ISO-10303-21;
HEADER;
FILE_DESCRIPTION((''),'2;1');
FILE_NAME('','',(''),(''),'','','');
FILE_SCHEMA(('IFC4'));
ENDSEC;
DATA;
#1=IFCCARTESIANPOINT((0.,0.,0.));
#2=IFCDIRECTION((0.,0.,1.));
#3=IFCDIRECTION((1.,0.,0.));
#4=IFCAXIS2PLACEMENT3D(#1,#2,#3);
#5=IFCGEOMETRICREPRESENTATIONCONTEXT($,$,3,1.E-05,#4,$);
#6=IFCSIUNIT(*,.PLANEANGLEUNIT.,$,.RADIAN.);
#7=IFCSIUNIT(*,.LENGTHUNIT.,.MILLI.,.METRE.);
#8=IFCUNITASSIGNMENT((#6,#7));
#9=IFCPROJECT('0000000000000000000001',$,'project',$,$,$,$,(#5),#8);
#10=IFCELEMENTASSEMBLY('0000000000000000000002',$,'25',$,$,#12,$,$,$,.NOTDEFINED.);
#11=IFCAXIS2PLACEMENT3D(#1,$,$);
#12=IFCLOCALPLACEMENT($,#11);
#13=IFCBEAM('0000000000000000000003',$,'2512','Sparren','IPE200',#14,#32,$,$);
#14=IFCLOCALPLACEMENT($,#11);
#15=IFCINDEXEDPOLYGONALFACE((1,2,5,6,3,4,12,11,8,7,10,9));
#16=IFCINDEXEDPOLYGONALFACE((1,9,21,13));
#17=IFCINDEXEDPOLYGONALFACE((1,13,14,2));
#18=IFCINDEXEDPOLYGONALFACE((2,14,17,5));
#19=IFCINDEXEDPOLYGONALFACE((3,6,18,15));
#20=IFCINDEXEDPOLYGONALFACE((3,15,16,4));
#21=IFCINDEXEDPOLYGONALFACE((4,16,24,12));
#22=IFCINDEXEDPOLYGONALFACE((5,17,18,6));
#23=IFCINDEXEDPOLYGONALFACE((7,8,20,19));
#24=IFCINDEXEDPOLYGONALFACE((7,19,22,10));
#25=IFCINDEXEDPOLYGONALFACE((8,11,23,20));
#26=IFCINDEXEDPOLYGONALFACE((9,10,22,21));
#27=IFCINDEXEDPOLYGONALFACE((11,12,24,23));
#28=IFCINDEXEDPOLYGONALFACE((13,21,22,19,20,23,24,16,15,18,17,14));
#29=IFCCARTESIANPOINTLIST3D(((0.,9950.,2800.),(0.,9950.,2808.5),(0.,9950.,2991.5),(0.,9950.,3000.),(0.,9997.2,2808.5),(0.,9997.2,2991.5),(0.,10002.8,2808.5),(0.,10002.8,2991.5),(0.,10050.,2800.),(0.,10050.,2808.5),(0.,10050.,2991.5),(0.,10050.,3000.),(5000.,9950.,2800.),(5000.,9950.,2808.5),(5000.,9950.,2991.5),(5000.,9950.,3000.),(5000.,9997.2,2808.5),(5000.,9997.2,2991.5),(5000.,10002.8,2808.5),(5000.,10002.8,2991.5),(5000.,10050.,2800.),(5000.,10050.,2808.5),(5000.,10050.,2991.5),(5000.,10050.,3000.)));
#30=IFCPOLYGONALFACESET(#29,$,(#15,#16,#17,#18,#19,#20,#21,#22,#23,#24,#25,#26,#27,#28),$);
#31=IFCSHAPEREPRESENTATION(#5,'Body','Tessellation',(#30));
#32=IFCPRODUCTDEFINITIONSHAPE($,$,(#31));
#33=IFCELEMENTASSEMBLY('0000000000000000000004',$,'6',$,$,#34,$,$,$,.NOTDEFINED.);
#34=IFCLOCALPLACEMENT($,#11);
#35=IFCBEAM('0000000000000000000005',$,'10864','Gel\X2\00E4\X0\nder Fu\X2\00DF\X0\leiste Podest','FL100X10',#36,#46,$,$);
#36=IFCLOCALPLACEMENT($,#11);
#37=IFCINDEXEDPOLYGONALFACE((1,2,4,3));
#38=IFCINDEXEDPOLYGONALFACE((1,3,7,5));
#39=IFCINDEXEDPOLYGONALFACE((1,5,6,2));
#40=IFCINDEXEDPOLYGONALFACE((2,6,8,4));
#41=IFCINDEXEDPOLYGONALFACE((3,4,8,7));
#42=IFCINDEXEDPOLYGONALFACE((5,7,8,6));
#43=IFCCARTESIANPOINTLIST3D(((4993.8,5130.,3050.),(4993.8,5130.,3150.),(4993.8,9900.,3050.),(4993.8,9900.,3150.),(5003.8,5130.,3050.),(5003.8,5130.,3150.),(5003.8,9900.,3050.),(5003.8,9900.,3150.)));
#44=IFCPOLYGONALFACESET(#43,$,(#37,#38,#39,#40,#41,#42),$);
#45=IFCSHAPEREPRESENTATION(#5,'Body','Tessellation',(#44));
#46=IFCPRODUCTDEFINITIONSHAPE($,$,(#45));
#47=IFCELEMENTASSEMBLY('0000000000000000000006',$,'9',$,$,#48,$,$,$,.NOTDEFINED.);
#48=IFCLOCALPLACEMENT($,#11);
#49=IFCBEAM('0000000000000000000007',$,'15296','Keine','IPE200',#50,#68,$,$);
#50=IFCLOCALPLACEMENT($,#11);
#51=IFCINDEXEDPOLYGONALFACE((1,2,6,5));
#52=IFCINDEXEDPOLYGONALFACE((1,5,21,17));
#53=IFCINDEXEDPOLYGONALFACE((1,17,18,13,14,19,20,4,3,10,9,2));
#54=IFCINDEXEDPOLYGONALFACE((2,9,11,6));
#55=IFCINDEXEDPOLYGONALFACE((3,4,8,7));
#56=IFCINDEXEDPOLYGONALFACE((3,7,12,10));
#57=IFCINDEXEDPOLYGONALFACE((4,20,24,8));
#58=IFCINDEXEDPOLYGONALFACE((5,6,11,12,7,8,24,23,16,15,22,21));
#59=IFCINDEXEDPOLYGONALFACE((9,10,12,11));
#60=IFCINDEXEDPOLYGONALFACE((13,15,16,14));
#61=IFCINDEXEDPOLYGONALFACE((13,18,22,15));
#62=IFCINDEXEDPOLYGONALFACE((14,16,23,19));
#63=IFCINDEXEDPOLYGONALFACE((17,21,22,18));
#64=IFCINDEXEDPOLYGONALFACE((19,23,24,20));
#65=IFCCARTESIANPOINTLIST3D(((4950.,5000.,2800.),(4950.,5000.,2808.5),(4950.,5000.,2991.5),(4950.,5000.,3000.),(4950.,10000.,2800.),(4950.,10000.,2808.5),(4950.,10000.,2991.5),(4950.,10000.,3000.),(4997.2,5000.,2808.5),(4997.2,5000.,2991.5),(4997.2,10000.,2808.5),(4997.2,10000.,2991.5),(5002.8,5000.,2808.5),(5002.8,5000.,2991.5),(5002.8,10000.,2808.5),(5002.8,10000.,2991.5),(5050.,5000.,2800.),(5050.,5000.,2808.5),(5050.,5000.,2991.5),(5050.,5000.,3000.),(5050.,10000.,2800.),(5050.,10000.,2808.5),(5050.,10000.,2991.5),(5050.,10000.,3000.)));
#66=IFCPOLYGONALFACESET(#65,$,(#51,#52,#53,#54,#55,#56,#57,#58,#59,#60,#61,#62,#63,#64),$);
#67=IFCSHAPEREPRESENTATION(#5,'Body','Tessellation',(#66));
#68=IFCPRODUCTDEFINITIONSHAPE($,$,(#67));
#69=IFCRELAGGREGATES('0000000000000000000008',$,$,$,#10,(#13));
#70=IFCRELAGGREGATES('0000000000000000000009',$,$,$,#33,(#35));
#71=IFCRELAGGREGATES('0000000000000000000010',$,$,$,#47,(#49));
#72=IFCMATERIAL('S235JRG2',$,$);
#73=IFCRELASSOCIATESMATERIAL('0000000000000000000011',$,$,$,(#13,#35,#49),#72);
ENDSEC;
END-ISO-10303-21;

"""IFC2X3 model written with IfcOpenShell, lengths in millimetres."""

from ifc_helpers import new_model, si_unit, frame, origin_with_axes, place, context, project, polyline, outline, extrude, material, element, aggregate, save


model = new_model("IFC2X3")

# Units and contexts
context_of_model = context(None, 3, precision=1e-05, world=origin_with_axes())
ifc_project = project(units=[si_unit("PLANEANGLEUNIT", "RADIAN"), si_unit("LENGTHUNIT", "METRE", prefix="MILLI")], contexts=[context_of_model])

# Element assembly, beam
assembly_1_placement = place(None, frame((5000.0, 10000.0, 6000.0), z_axis=(0.0, 0.0, 1.0), x_axis=(-1.0, 0.0, 0.0)))
assembly_1 = element("IfcElementAssembly", 1, at=assembly_1_placement, Name="25", PredefinedType="NOTDEFINED")
ifc_material = material(Name="S235JRG2")
placement_1 = place(None, frame((5000.0, 10000.0, 2900.0), z_axis=(0.0, 0.0, 1.0), x_axis=(-1.0, 0.0, 0.0)))
beam_1_placement = place(placement_1, origin_with_axes())
beam_1 = element("IfcBeam", 2, at=beam_1_placement, material=ifc_material, Name="2512", Description="Sparren", ObjectType="IPE200", context=context_of_model, shape_type="SweptSolid", body=[
    extrude(outline(polyline([(50.0, -100.0), (50.0, -91.5), (2.8, -91.5), (2.8, 91.5), (50.0, 91.5), (50.0, 100.0), (-50.0, 100.0), (-50.0, 91.5), (-2.8, 91.5), (-2.8, -91.5), (-50.0, -91.5), (-50.0, -100.0), (50.0, -100.0), (50.0, -100.0)])), frame((0.0, 0.0, 0.0), z_axis=(1.0, 0.0, 0.0), x_axis=(0.0, 1.0, 0.0)), (0.0, 0.0, 1.0), 5000.0),
])
aggregate(assembly_1, [beam_1])

# Element assembly, beam
assembly_2_placement = place(None, frame((1.2, 5130.0, 6100.0), z_axis=(0.0, 0.0, 1.0), x_axis=(0.0, 1.0, 0.0)))
assembly_2 = element("IfcElementAssembly", 3, at=assembly_2_placement, Name="6", PredefinedType="NOTDEFINED")
placement_2 = place(None, frame((4998.8, 9900.0, 3100.0), z_axis=(0.0, 0.0, 1.0), x_axis=(0.0, -1.0, 0.0)))
beam_2_placement = place(placement_2, origin_with_axes())
beam_2 = element("IfcBeam", 4, at=beam_2_placement, material=ifc_material, Name="10864", Description="Geländer Fußleiste Podest", ObjectType="FL100X10", context=context_of_model, shape_type="SweptSolid", body=[
    extrude(outline(polyline([(5.0, -50.0), (5.0, 50.0), (-5.0, 50.0), (-5.0, -50.0), (5.0, -50.0), (5.0, -50.0)])), frame((0.0, 0.0, 0.0), z_axis=(1.0, 0.0, 0.0), x_axis=(0.0, 1.0, 0.0)), (0.0, 0.0, 1.0), 4770.0),
])
aggregate(assembly_2, [beam_2])

# Element assembly, beam
assembly_3_placement = place(None, frame((5000.0, 10000.0, 6000.0), z_axis=(0.0, 0.0, 1.0), x_axis=(0.0, -1.0, 0.0)))
assembly_3 = element("IfcElementAssembly", 5, at=assembly_3_placement, Name="9", PredefinedType="NOTDEFINED")
placement_3 = place(None, frame((5000.0, 10000.0, 2900.0), z_axis=(0.0, 0.0, 1.0), x_axis=(0.0, -1.0, 0.0)))
beam_3_placement = place(placement_3, origin_with_axes())
beam_3 = element("IfcBeam", 6, at=beam_3_placement, material=ifc_material, Name="15296", Description="Keine", ObjectType="IPE200", context=context_of_model, shape_type="SweptSolid", body=[
    extrude(outline(polyline([(50.0, -100.0), (50.0, -91.5), (2.8, -91.5), (2.8, 91.5), (50.0, 91.5), (50.0, 100.0), (-50.0, 100.0), (-50.0, 91.5), (-2.8, 91.5), (-2.8, -91.5), (-50.0, -91.5), (-50.0, -100.0), (50.0, -100.0), (50.0, -100.0)])), frame((0.0, 0.0, 0.0), z_axis=(1.0, 0.0, 0.0), x_axis=(0.0, 1.0, 0.0)), (0.0, 0.0, 1.0), 5000.0),
])
aggregate(assembly_3, [beam_3])

save(model, "model.ifc")
